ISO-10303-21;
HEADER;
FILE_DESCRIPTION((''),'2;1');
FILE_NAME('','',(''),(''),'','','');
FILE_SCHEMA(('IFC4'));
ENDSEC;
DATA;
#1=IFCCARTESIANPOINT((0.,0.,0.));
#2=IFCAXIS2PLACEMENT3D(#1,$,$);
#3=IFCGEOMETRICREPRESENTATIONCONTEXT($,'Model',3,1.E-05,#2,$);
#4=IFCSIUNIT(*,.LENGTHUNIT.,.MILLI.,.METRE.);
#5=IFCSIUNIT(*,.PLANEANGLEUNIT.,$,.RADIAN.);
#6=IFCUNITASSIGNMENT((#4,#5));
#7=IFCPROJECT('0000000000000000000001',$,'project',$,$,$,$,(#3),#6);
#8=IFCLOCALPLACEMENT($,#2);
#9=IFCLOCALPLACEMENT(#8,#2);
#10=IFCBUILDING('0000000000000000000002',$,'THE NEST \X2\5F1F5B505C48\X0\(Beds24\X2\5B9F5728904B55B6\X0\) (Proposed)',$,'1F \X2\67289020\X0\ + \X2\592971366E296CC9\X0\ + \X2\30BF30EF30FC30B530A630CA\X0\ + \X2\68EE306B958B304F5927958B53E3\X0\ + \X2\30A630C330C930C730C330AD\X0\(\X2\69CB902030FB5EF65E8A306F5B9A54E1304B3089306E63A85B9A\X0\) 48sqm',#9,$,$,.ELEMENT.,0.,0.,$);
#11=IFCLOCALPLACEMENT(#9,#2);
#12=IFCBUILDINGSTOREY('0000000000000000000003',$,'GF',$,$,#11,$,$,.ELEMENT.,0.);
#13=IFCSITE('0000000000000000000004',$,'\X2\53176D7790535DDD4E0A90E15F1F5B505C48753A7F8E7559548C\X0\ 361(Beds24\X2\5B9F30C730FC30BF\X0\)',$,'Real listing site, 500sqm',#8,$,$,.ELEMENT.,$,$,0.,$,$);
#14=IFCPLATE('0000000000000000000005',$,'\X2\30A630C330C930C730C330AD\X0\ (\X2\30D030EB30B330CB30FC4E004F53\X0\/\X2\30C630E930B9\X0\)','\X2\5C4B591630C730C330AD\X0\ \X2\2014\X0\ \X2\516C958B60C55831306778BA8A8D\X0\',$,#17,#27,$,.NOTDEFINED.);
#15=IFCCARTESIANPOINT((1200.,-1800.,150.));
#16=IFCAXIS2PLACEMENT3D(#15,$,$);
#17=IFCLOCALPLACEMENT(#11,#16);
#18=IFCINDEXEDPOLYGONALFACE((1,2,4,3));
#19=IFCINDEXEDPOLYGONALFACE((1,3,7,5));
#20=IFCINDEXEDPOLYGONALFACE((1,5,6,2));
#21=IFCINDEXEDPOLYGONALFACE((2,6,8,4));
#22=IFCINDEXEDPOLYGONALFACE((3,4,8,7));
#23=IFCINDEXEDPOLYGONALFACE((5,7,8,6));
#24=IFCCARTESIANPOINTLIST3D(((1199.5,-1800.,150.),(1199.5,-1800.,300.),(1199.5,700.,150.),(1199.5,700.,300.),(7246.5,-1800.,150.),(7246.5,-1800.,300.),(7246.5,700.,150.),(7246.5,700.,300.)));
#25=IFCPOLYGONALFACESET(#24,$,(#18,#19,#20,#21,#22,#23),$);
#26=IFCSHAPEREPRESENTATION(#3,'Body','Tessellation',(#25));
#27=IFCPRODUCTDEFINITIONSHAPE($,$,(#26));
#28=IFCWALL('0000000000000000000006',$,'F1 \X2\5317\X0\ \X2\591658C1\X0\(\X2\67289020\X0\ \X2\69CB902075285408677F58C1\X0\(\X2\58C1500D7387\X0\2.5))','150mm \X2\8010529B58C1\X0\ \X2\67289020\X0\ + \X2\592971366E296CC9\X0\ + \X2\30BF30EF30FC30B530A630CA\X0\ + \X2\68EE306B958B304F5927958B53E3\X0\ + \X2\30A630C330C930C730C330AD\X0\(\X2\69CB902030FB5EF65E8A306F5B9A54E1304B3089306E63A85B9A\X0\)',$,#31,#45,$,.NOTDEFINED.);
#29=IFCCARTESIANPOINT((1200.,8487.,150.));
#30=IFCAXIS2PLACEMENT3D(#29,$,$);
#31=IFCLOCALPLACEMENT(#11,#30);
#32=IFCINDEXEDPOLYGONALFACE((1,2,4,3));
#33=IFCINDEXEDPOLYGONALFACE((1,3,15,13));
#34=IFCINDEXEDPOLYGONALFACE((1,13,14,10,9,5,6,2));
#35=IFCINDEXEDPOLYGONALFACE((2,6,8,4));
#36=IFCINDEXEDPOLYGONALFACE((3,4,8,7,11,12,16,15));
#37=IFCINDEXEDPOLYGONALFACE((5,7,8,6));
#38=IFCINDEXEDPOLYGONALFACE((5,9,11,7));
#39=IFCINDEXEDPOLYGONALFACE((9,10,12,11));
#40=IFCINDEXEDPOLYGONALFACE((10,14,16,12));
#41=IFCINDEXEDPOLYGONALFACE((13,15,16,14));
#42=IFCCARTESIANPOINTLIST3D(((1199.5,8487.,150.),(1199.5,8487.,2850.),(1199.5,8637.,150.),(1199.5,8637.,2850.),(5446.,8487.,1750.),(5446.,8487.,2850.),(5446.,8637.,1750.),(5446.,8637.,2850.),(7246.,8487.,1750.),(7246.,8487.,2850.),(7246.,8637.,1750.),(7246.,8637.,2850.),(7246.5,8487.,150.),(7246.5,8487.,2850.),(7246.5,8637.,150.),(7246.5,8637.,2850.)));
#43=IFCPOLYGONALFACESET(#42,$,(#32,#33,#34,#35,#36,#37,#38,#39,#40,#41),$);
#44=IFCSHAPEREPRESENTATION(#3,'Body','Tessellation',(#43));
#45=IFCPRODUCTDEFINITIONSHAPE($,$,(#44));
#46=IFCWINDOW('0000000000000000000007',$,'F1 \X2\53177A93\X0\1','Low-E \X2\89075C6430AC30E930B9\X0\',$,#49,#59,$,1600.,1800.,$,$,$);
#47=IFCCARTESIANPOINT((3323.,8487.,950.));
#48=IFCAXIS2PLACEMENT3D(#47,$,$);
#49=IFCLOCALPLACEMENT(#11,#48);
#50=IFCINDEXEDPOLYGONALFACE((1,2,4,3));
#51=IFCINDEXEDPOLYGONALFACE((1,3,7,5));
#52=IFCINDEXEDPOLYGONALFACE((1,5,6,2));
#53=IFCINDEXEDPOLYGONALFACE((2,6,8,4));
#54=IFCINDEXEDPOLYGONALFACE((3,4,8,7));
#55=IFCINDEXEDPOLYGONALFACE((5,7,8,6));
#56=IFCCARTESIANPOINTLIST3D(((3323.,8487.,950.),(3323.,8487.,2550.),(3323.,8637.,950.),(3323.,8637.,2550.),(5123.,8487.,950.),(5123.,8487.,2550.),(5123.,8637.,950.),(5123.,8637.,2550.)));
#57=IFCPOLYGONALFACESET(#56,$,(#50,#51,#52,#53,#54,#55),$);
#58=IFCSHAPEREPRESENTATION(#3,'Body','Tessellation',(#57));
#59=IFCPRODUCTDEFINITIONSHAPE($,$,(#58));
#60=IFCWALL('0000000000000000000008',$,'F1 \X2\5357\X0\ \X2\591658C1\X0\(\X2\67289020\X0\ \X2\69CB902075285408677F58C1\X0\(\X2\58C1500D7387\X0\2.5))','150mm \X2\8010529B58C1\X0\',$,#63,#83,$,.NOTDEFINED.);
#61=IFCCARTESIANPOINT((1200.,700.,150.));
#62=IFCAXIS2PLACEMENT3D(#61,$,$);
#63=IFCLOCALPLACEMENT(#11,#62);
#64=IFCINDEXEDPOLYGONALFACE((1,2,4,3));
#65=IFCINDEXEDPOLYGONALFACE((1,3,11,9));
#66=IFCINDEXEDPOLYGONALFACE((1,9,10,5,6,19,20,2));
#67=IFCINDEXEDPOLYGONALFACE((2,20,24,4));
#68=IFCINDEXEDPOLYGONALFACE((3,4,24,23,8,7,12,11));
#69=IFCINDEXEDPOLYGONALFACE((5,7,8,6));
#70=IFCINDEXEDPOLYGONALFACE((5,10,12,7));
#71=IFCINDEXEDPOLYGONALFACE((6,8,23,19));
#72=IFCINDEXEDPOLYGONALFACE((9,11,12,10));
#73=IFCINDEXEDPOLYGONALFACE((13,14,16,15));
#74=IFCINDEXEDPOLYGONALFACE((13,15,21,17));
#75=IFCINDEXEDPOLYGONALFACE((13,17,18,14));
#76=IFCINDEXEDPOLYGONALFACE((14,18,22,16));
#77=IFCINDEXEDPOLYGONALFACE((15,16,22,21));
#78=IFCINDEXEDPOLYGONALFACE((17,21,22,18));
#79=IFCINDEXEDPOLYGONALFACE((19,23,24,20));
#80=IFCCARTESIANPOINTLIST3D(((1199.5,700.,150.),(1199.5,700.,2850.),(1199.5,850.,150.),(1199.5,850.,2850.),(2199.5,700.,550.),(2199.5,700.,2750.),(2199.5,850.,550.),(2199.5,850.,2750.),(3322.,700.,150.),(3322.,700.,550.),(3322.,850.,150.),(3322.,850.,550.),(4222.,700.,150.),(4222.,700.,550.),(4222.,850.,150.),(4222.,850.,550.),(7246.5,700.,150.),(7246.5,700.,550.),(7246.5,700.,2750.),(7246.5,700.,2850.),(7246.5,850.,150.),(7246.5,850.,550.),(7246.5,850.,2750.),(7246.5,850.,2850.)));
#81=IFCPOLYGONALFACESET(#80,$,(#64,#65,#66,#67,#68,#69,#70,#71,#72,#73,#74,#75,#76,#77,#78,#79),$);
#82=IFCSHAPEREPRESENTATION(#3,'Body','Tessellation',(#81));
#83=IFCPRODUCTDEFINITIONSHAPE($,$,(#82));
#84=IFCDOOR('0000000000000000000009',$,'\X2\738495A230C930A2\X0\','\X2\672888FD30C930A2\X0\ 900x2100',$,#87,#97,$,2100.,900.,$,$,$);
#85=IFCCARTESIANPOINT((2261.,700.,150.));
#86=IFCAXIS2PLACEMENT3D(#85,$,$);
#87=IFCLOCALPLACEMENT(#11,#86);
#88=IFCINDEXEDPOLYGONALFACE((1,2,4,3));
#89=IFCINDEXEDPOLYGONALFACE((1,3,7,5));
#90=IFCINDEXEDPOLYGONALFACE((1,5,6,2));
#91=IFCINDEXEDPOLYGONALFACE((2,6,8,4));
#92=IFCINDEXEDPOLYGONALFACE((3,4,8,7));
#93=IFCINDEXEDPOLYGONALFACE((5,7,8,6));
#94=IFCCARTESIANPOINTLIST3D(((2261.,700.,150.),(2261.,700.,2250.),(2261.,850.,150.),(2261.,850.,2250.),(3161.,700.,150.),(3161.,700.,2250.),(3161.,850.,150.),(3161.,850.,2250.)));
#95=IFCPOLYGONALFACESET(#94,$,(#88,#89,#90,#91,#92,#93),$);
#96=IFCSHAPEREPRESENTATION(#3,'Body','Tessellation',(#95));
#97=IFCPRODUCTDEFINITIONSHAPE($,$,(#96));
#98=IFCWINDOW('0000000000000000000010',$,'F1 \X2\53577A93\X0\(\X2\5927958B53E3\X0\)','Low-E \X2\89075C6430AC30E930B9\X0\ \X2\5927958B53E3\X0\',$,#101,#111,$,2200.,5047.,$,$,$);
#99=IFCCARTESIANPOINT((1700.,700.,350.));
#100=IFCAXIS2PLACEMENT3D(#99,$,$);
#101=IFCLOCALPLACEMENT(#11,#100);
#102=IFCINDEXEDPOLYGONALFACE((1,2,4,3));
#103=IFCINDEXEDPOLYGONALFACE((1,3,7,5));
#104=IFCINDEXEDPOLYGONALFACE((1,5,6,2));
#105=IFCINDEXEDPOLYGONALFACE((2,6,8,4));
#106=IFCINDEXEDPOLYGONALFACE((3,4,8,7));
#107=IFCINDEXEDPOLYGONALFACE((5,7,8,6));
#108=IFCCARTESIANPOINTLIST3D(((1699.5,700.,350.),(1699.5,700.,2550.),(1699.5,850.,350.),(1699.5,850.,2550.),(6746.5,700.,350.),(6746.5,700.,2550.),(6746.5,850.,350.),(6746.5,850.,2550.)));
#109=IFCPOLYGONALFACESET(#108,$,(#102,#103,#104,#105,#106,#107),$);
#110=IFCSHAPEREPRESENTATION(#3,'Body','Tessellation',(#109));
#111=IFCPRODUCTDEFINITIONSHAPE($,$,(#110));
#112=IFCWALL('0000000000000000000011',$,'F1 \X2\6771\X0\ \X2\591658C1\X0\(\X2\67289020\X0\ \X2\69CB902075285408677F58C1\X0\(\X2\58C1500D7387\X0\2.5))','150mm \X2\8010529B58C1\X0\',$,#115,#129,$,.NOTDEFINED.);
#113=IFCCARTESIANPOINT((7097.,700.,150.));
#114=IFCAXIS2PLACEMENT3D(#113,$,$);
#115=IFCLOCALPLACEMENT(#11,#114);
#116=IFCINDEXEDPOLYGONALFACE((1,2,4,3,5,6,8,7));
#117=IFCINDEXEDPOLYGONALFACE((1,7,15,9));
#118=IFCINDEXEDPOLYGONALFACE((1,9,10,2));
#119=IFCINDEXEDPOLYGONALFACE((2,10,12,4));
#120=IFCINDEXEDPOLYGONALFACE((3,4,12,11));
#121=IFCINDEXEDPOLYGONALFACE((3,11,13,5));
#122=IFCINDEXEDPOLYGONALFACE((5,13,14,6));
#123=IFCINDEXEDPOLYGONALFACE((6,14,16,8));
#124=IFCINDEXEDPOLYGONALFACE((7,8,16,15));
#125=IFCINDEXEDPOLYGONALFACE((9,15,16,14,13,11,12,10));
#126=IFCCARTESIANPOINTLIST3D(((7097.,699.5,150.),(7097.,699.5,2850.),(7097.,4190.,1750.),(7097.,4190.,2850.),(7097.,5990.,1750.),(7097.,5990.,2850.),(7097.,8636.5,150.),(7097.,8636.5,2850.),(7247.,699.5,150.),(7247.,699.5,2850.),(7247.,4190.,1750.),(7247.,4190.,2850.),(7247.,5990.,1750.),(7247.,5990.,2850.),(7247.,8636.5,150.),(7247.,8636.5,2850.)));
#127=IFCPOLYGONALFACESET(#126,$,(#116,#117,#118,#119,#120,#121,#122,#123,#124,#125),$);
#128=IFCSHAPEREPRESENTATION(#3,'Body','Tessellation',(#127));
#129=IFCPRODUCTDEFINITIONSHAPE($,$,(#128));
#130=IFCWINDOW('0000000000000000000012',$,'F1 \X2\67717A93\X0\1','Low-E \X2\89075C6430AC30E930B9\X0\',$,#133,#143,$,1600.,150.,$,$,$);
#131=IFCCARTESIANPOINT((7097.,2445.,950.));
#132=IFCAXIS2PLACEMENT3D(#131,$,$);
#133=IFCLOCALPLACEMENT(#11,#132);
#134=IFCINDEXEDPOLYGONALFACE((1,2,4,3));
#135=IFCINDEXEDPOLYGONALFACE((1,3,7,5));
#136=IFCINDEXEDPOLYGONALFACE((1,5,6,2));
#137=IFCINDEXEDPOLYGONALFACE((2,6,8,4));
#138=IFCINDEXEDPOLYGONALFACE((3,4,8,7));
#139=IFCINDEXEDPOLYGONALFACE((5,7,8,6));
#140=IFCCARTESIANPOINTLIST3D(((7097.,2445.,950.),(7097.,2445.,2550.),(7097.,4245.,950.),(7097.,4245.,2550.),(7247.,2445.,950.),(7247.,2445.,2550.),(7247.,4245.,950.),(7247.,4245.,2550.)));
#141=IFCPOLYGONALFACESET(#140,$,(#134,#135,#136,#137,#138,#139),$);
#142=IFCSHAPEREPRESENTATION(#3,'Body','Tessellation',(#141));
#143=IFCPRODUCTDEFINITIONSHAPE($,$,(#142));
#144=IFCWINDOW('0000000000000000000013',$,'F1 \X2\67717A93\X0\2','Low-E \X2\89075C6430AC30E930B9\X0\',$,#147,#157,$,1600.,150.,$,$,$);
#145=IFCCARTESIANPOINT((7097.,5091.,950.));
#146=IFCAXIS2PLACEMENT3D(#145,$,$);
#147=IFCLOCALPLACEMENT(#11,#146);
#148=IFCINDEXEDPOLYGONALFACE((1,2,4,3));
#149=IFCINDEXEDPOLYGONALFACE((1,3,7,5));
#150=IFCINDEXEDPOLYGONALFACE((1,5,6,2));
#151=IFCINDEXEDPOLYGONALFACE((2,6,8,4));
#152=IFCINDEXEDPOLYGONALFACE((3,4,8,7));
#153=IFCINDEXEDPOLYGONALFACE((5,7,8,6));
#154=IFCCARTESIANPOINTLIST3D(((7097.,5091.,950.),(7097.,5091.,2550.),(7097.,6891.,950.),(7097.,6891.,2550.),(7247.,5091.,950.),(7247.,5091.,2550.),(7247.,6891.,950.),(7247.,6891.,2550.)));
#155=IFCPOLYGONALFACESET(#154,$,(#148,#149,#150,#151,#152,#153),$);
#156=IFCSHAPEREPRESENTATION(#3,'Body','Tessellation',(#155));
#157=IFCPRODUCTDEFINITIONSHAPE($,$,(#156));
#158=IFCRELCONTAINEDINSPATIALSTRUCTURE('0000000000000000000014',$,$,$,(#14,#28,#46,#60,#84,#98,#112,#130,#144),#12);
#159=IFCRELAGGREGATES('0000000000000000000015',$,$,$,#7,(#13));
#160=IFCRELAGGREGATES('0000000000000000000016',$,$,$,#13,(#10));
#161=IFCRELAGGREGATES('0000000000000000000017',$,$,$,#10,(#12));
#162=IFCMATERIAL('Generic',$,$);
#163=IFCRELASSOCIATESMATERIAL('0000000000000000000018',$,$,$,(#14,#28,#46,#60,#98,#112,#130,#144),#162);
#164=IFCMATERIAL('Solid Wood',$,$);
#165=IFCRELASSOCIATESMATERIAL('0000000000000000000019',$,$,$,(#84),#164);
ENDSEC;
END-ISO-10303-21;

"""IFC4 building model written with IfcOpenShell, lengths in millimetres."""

from ifc_helpers import new_model, si_unit, frame, frame_2d, origin, place, context, project, spatial, rectangle, extrude, material, element, fill, save


model = new_model("IFC4")

# Units and contexts
model_context = context("Model", 3, precision=1e-05, world=origin())
ifc_project = project(units=[si_unit("LENGTHUNIT", "METRE", prefix="MILLI"), si_unit("PLANEANGLEUNIT", "RADIAN")], contexts=[model_context])

# Site, building, storey
site_placement = place(None, origin())
site = spatial("IfcSite", under=ifc_project, at=site_placement, Name="北海道川上郡弟子屈町美留和 361(Beds24実データ)", ObjectType="Real listing site, 500sqm", CompositionType="ELEMENT", RefElevation=0.0)
building_placement = place(site_placement, origin())
building = spatial("IfcBuilding", under=site, at=building_placement, Name="THE NEST 弟子屈(Beds24実在運営) (Proposed)", ObjectType="1F 木造 + 天然温泉 + タワーサウナ + 森に開く大開口 + ウッドデッキ(構造・延床は定員からの推定) 48sqm", CompositionType="ELEMENT", ElevationOfRefHeight=0.0, ElevationOfTerrain=0.0)
storey_placement = place(building_placement, origin())
storey = spatial("IfcBuildingStorey", under=building, at=storey_placement, Name="GF", CompositionType="ELEMENT", Elevation=0.0)

# Shared definitions
ifc_material_1 = material(Name="Generic")

# Plate
plate_placement = place(storey_placement, frame((1200.0, -1800.0, 150.0)))
element("IfcPlate", 1, at=plate_placement, inside=storey, material=ifc_material_1, Name="ウッドデッキ (バルコニー一体/テラス)", Description="屋外デッキ — 公開情報で確認", PredefinedType="NOTDEFINED", context=model_context, shape_type="SweptSolid", body=[
    extrude(rectangle(XDim=6047.0, YDim=2500.0, at=frame_2d((3023.0, 1250.0))), frame((1200.0, -1800.0, 150.0)), (0.0, 0.0, 1.0), 150.0),
])

# Wall, opening, window
wall_1_placement = place(storey_placement, frame((1200.0, 8487.0, 150.0)))
wall_1 = element("IfcWall", 2, at=wall_1_placement, inside=storey, material=ifc_material_1, Name="F1 北 外壁(木造 構造用合板壁(壁倍率2.5))", Description="150mm 耐力壁 木造 + 天然温泉 + タワーサウナ + 森に開く大開口 + ウッドデッキ(構造・延床は定員からの推定)", PredefinedType="NOTDEFINED", context=model_context, shape_type="SweptSolid", body=[
    extrude(rectangle(XDim=6047.0, YDim=150.0, at=frame_2d((3023.0, 75.0))), frame((1200.0, 8487.0, 150.0)), (0.0, 0.0, 1.0), 2700.0),
])
opening_1_placement = place(storey_placement, frame((3323.0, 8487.0, 950.0)))
opening_1 = element("IfcOpeningElement", 3, at=opening_1_placement, cuts=wall_1, PredefinedType="NOTDEFINED", context=model_context, shape_type="SweptSolid", body=[
    extrude(rectangle(XDim=1800.0, YDim=150.0, at=frame_2d((900.0, 75.0))), frame((3323.0, 8487.0, 950.0)), (0.0, 0.0, 1.0), 1600.0),
])
window_1_placement = place(storey_placement, frame((3323.0, 8487.0, 950.0)))
window_1 = element("IfcWindow", 4, at=window_1_placement, inside=storey, material=ifc_material_1, Name="F1 北窓1", Description="Low-E 複層ガラス", OverallHeight=1600.0, OverallWidth=1800.0, context=model_context, shape_type="SweptSolid", body=[
    extrude(rectangle(XDim=1800.0, YDim=150.0, at=frame_2d((900.0, 75.0))), frame((3323.0, 8487.0, 950.0)), (0.0, 0.0, 1.0), 1600.0),
])
fill(opening_1, window_1)

# Wall, openings, door, window
wall_2_placement = place(storey_placement, frame((1200.0, 700.0, 150.0)))
wall_2 = element("IfcWall", 5, at=wall_2_placement, inside=storey, material=ifc_material_1, Name="F1 南 外壁(木造 構造用合板壁(壁倍率2.5))", Description="150mm 耐力壁", PredefinedType="NOTDEFINED", context=model_context, shape_type="SweptSolid", body=[
    extrude(rectangle(XDim=6047.0, YDim=150.0, at=frame_2d((3023.0, 75.0))), frame((1200.0, 700.0, 150.0)), (0.0, 0.0, 1.0), 2700.0),
])
opening_2_placement = place(storey_placement, frame((2261.0, 700.0, 150.0)))
opening_2 = element("IfcOpeningElement", 6, at=opening_2_placement, cuts=wall_2, PredefinedType="NOTDEFINED", context=model_context, shape_type="SweptSolid", body=[
    extrude(rectangle(XDim=900.0, YDim=150.0, at=frame_2d((450.0, 75.0))), frame((2261.0, 700.0, 150.0)), (0.0, 0.0, 1.0), 2100.0),
])
opening_3_placement = place(storey_placement, frame((1700.0, 700.0, 350.0)))
opening_3 = element("IfcOpeningElement", 7, at=opening_3_placement, cuts=wall_2, PredefinedType="NOTDEFINED", context=model_context, shape_type="SweptSolid", body=[
    extrude(rectangle(XDim=5047.0, YDim=150.0, at=frame_2d((2523.0, 75.0))), frame((1700.0, 700.0, 350.0)), (0.0, 0.0, 1.0), 2200.0),
])
ifc_material_2 = material(Name="Solid Wood")
door_placement = place(storey_placement, frame((2261.0, 700.0, 150.0)))
door = element("IfcDoor", 8, at=door_placement, inside=storey, material=ifc_material_2, Name="玄関ドア", Description="木製ドア 900x2100", OverallHeight=2100.0, OverallWidth=900.0, context=model_context, shape_type="SweptSolid", body=[
    extrude(rectangle(XDim=900.0, YDim=150.0, at=frame_2d((450.0, 75.0))), frame((2261.0, 700.0, 150.0)), (0.0, 0.0, 1.0), 2100.0),
])
fill(opening_2, door)
window_2_placement = place(storey_placement, frame((1700.0, 700.0, 350.0)))
window_2 = element("IfcWindow", 9, at=window_2_placement, inside=storey, material=ifc_material_1, Name="F1 南窓(大開口)", Description="Low-E 複層ガラス 大開口", OverallHeight=2200.0, OverallWidth=5047.0, context=model_context, shape_type="SweptSolid", body=[
    extrude(rectangle(XDim=5047.0, YDim=150.0, at=frame_2d((2523.0, 75.0))), frame((1700.0, 700.0, 350.0)), (0.0, 0.0, 1.0), 2200.0),
])
fill(opening_3, window_2)

# Wall, openings, windows
wall_3_placement = place(storey_placement, frame((7097.0, 700.0, 150.0)))
wall_3 = element("IfcWall", 10, at=wall_3_placement, inside=storey, material=ifc_material_1, Name="F1 東 外壁(木造 構造用合板壁(壁倍率2.5))", Description="150mm 耐力壁", PredefinedType="NOTDEFINED", context=model_context, shape_type="SweptSolid", body=[
    extrude(rectangle(XDim=150.0, YDim=7937.0, at=frame_2d((75.0, 3968.0))), frame((7097.0, 700.0, 150.0)), (0.0, 0.0, 1.0), 2700.0),
])
opening_4_placement = place(storey_placement, frame((7097.0, 2445.0, 950.0)))
opening_4 = element("IfcOpeningElement", 11, at=opening_4_placement, cuts=wall_3, PredefinedType="NOTDEFINED", context=model_context, shape_type="SweptSolid", body=[
    extrude(rectangle(XDim=150.0, YDim=1800.0, at=frame_2d((75.0, 900.0))), frame((7097.0, 2445.0, 950.0)), (0.0, 0.0, 1.0), 1600.0),
])
opening_5_placement = place(storey_placement, frame((7097.0, 5091.0, 950.0)))
opening_5 = element("IfcOpeningElement", 12, at=opening_5_placement, cuts=wall_3, PredefinedType="NOTDEFINED", context=model_context, shape_type="SweptSolid", body=[
    extrude(rectangle(XDim=150.0, YDim=1800.0, at=frame_2d((75.0, 900.0))), frame((7097.0, 5091.0, 950.0)), (0.0, 0.0, 1.0), 1600.0),
])
window_3_placement = place(storey_placement, frame((7097.0, 2445.0, 950.0)))
window_3 = element("IfcWindow", 13, at=window_3_placement, inside=storey, material=ifc_material_1, Name="F1 東窓1", Description="Low-E 複層ガラス", OverallHeight=1600.0, OverallWidth=150.0, context=model_context, shape_type="SweptSolid", body=[
    extrude(rectangle(XDim=150.0, YDim=1800.0, at=frame_2d((75.0, 900.0))), frame((7097.0, 2445.0, 950.0)), (0.0, 0.0, 1.0), 1600.0),
])
fill(opening_4, window_3)
window_4_placement = place(storey_placement, frame((7097.0, 5091.0, 950.0)))
window_4 = element("IfcWindow", 14, at=window_4_placement, inside=storey, material=ifc_material_1, Name="F1 東窓2", Description="Low-E 複層ガラス", OverallHeight=1600.0, OverallWidth=150.0, context=model_context, shape_type="SweptSolid", body=[
    extrude(rectangle(XDim=150.0, YDim=1800.0, at=frame_2d((75.0, 900.0))), frame((7097.0, 5091.0, 950.0)), (0.0, 0.0, 1.0), 1600.0),
])
fill(opening_5, window_4)

save(model, "model.ifc")
